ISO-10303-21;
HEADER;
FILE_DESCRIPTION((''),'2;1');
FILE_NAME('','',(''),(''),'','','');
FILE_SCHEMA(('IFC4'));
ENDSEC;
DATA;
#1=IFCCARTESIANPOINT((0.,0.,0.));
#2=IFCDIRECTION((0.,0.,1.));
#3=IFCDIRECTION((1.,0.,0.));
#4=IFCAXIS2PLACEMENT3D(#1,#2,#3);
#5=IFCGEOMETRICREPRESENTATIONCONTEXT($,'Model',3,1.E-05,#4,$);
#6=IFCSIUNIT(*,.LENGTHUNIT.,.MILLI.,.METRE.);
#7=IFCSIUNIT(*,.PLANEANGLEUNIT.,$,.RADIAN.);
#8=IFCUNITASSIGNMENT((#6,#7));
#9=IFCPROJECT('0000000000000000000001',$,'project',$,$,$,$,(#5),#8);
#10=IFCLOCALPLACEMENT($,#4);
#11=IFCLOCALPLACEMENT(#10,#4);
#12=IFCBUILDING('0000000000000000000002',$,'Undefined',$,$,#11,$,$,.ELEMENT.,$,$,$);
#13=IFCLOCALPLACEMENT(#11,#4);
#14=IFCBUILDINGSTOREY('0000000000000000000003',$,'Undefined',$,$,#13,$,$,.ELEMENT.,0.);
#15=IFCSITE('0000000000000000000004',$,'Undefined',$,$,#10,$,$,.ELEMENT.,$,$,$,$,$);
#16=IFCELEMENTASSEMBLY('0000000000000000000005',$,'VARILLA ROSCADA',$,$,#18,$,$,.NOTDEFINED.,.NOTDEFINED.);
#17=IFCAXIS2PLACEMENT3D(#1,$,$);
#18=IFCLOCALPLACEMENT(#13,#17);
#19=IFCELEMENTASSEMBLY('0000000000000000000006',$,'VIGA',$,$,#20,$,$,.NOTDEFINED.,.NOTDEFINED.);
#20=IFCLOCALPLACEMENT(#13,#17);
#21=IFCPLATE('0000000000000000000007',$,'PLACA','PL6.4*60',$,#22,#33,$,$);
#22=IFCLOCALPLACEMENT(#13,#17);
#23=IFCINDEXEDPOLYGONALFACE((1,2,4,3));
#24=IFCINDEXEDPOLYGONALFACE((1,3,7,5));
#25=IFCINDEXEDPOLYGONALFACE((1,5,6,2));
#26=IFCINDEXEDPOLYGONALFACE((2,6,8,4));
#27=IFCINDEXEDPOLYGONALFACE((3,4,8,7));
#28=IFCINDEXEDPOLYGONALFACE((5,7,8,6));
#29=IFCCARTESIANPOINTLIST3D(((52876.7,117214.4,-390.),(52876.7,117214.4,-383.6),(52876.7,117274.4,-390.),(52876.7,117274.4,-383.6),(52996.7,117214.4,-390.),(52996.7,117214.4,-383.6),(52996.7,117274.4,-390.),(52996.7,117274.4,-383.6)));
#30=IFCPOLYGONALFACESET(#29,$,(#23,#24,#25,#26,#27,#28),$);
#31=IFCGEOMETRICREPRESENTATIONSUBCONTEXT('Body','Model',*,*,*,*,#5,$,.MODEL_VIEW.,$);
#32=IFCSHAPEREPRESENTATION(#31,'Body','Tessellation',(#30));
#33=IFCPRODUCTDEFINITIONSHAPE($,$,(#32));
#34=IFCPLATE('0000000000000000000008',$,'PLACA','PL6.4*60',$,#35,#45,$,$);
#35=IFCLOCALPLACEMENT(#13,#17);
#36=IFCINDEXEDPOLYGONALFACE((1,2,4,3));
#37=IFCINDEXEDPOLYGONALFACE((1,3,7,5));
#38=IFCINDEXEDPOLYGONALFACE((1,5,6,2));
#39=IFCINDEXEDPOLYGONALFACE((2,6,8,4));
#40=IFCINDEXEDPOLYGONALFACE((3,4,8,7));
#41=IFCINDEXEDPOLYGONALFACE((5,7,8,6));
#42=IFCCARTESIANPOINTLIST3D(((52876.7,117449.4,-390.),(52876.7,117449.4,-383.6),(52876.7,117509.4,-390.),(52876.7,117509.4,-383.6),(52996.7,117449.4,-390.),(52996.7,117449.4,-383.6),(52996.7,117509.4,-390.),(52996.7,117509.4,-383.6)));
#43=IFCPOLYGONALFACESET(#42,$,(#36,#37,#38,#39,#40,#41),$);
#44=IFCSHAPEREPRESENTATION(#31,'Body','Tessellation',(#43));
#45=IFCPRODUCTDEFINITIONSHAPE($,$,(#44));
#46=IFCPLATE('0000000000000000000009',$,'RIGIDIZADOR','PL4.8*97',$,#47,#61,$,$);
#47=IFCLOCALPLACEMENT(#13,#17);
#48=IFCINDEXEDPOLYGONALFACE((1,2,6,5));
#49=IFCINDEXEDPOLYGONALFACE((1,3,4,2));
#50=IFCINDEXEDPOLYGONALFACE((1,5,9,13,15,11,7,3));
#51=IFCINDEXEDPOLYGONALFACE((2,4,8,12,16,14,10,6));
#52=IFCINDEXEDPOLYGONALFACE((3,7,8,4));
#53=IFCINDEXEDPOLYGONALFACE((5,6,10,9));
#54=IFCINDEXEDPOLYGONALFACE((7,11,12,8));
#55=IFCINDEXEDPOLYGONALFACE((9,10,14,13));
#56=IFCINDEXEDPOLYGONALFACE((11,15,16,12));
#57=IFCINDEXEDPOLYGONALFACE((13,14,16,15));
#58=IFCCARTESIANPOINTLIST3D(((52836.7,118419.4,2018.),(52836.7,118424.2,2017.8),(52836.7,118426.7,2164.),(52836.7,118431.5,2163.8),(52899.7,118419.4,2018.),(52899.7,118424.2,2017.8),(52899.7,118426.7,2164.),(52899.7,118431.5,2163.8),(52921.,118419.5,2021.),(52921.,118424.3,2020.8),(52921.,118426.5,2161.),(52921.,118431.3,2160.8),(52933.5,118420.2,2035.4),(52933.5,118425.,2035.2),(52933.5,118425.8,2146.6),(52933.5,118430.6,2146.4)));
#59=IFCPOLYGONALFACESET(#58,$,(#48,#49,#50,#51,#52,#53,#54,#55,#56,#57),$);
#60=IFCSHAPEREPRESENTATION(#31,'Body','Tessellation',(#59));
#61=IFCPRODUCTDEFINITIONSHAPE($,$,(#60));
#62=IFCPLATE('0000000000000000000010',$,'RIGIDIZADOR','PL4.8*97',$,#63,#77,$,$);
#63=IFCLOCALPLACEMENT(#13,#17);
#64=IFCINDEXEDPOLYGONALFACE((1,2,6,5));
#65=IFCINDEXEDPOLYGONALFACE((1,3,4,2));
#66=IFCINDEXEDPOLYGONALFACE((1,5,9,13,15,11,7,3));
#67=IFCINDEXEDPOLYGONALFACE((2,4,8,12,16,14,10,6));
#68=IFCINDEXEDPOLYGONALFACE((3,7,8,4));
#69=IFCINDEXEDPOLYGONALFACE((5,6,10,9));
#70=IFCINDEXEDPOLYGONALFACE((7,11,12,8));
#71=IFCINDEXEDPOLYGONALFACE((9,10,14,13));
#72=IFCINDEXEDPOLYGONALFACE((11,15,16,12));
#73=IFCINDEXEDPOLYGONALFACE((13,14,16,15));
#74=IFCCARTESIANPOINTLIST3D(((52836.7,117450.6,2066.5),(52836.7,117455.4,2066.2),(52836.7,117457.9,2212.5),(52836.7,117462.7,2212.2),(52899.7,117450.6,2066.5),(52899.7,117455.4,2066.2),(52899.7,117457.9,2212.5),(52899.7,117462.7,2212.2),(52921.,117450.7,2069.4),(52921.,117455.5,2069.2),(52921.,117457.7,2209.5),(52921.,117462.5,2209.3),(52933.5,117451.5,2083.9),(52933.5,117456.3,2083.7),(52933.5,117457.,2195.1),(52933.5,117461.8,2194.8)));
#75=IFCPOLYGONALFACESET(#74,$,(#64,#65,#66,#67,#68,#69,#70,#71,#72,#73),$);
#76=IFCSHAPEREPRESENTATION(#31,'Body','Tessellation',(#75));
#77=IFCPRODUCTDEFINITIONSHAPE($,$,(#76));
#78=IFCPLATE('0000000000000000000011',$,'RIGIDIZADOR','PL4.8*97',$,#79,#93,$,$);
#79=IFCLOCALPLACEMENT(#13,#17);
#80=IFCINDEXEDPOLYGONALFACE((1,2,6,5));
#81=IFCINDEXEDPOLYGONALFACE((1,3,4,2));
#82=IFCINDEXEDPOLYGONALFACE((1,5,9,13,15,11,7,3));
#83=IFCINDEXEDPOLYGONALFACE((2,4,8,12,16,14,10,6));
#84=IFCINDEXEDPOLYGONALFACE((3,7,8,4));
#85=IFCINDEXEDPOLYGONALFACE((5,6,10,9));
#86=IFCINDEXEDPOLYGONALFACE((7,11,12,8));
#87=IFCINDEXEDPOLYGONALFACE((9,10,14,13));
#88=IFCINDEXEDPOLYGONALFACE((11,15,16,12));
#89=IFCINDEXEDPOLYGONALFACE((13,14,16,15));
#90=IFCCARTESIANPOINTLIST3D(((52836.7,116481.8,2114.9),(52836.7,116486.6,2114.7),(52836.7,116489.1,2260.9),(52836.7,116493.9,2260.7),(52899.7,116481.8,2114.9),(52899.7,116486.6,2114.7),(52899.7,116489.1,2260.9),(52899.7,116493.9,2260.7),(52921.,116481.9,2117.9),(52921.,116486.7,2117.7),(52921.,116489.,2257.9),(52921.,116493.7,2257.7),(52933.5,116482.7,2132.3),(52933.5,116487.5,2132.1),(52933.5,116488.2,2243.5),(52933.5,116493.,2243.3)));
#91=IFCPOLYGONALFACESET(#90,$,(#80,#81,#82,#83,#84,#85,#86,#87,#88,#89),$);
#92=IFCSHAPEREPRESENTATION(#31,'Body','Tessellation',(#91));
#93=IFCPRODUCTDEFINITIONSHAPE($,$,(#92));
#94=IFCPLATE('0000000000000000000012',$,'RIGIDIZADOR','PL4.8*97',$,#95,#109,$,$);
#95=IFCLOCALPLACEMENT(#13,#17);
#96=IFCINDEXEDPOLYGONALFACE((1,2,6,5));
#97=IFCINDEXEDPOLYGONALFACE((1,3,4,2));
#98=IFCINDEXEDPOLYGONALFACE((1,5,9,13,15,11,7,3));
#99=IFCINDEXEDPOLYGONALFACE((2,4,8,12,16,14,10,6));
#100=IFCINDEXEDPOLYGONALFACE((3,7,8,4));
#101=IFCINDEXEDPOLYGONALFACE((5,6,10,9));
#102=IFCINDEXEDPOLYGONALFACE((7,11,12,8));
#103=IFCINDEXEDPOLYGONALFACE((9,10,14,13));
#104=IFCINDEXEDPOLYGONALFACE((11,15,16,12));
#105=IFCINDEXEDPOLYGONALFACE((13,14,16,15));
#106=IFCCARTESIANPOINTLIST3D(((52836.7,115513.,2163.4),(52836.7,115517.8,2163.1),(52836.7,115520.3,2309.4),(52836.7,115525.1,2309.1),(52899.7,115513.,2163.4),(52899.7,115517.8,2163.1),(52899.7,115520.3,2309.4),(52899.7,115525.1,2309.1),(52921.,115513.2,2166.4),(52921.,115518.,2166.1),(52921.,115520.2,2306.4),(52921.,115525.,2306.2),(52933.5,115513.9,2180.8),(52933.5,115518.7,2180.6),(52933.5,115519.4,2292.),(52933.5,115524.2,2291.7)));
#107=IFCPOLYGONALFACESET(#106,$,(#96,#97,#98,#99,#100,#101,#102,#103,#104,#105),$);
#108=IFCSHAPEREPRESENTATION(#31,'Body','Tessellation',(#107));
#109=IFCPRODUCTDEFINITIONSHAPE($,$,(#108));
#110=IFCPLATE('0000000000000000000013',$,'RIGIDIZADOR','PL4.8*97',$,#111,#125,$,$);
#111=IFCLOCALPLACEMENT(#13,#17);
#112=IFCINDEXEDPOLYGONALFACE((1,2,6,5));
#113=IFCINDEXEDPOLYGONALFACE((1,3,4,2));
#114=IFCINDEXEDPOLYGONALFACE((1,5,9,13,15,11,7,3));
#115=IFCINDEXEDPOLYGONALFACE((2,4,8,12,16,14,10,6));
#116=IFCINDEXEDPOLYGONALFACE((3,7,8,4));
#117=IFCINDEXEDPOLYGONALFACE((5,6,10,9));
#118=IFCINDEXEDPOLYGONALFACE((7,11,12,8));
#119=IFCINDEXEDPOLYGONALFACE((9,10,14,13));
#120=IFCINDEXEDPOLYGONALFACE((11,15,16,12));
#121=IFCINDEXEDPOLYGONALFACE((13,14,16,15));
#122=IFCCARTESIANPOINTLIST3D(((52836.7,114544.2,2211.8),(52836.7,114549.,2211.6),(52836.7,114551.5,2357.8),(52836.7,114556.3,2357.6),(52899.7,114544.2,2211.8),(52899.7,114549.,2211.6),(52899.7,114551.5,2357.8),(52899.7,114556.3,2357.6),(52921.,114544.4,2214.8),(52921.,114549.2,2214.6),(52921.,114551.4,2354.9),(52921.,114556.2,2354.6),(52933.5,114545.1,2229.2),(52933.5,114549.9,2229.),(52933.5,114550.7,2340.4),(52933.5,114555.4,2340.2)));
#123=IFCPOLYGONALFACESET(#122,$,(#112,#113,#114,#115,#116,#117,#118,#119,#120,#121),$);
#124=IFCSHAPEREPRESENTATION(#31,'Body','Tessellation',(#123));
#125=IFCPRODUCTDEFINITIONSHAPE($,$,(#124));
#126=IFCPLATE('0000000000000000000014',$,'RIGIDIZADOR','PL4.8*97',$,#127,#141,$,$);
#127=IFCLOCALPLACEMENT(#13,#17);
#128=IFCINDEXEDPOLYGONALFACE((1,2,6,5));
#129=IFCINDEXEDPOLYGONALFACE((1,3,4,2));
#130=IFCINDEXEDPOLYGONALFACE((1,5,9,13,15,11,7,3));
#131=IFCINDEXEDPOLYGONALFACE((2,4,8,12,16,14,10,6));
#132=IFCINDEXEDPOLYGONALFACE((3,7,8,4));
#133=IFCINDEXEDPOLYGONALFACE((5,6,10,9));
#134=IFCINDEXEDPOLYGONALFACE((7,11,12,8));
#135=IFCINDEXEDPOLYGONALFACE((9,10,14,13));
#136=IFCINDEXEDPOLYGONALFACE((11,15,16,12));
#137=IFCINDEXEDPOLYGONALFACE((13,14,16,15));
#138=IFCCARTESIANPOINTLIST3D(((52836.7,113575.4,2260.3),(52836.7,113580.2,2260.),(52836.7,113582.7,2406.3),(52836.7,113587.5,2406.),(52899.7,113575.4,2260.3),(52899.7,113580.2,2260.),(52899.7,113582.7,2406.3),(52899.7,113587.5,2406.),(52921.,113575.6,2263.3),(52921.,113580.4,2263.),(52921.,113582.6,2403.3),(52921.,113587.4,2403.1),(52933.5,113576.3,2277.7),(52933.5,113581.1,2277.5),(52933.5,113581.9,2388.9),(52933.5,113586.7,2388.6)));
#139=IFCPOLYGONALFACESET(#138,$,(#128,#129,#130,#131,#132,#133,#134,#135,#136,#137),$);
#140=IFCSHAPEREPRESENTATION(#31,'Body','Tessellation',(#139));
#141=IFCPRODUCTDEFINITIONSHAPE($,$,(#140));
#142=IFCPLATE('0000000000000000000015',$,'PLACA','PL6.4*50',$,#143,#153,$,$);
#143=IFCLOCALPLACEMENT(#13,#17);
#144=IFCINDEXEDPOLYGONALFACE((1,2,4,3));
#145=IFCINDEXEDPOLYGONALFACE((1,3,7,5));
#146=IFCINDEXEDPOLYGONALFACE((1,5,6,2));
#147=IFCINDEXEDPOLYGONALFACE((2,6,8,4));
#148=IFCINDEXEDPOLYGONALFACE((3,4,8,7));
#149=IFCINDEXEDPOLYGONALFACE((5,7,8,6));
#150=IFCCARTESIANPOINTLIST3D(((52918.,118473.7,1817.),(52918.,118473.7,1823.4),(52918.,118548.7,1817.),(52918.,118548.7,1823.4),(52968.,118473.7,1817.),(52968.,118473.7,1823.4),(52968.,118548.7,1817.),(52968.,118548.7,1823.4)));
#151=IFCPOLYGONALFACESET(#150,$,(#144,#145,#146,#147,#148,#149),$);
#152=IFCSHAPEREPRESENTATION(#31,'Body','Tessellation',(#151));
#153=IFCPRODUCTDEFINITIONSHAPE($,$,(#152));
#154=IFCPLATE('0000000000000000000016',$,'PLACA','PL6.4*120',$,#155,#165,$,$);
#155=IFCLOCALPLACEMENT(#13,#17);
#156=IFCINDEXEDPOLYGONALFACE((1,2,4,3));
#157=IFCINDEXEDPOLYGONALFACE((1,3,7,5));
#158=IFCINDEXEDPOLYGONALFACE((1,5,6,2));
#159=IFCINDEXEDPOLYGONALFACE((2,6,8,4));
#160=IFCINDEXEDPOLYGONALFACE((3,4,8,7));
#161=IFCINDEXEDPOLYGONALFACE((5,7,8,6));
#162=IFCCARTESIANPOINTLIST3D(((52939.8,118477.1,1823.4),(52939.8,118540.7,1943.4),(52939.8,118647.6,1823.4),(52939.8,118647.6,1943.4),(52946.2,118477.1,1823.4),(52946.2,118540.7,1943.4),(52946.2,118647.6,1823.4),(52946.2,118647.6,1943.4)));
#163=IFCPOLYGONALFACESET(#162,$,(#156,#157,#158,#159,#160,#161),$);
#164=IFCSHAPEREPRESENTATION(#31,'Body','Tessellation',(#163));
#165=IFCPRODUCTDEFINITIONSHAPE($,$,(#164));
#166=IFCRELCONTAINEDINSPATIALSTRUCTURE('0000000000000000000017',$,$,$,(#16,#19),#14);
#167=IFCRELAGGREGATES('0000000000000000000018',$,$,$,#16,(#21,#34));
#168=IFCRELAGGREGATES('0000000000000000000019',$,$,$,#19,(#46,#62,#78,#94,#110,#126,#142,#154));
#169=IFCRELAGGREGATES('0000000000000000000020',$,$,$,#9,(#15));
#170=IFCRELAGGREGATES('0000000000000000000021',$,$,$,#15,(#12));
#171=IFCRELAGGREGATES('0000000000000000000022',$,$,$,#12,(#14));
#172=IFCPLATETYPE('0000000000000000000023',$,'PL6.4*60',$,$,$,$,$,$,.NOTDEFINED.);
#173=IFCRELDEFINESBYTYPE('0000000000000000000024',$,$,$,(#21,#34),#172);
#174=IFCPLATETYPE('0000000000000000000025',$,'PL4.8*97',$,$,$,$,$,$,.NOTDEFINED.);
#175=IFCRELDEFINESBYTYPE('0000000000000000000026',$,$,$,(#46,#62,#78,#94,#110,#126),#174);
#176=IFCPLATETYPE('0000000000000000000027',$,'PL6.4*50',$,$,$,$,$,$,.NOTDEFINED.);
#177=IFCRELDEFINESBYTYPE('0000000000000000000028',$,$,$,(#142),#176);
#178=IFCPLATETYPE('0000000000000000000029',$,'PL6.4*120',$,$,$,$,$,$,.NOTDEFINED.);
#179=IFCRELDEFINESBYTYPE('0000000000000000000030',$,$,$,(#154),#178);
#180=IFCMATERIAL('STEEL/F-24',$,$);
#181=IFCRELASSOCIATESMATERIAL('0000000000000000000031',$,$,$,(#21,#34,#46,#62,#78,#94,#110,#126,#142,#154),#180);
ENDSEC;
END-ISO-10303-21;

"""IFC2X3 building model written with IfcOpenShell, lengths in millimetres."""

from ifc_helpers import new_model, si_unit, frame, origin_with_axes, place, context, subcontext, project, spatial, polyline, outline, extrude, material, type_object, element, aggregate, save


model = new_model("IFC2X3")

# Units and contexts
model_context = context("Model", 3, precision=1e-05, world=origin_with_axes())
body_context = subcontext(model_context, "Body", "Model", "MODEL_VIEW")
ifc_project = project(units=[si_unit("LENGTHUNIT", "METRE", prefix="MILLI"), si_unit("PLANEANGLEUNIT", "RADIAN")], contexts=[model_context])

# Site, building, storey
site_placement = place(None, origin_with_axes())
site = spatial("IfcSite", under=ifc_project, at=site_placement, Name="Undefined", CompositionType="ELEMENT")
building_placement = place(site_placement, origin_with_axes())
building = spatial("IfcBuilding", under=site, at=building_placement, Name="Undefined", CompositionType="ELEMENT")
storey_placement = place(building_placement, origin_with_axes())
storey = spatial("IfcBuildingStorey", under=building, at=storey_placement, Name="Undefined", CompositionType="ELEMENT", Elevation=0.0)

# Element assembly
assembly_1_placement = place(storey_placement, origin_with_axes())
assembly_1 = element("IfcElementAssembly", 1, at=assembly_1_placement, inside=storey, Name="VARILLA ROSCADA", AssemblyPlace="NOTDEFINED", PredefinedType="NOTDEFINED")

# Element assembly
assembly_2_placement = place(storey_placement, origin_with_axes())
assembly_2 = element("IfcElementAssembly", 2, at=assembly_2_placement, inside=storey, Name="VIGA", AssemblyPlace="NOTDEFINED", PredefinedType="NOTDEFINED")
ifc_material_1 = material(Name="STEEL/F-24")

# Plates
plate_type_1 = type_object("IfcPlateType", Name="PL6.4*60", PredefinedType="NOTDEFINED")
plate_1_placement = place(assembly_1_placement, frame((52876.7, 117214.4, -386.8), z_axis=(0.0, 0.0, 1.0), x_axis=(1.0, 0.0, 0.0)))
plate_1 = element("IfcPlate", 3, at=plate_1_placement, type_object=plate_type_1, material=ifc_material_1, Name="PLACA", Description="PL6.4*60", context=body_context, shape_type="SweptSolid", body=[
    extrude(outline(polyline([(0.0, 0.0), (120.0, 0.0), (120.0, 60.0), (0.0, 60.0), (0.0, 0.0)])), frame((0.0, 0.0, -3.2), z_axis=(0.0, 0.0, 1.0), x_axis=(1.0, 0.0, 0.0)), (0.0, 0.0, 1.0), 6.4),
])
plate_2_placement = place(assembly_1_placement, frame((52876.7, 117449.4, -386.8), z_axis=(0.0, 0.0, 1.0), x_axis=(1.0, 0.0, 0.0)))
plate_2 = element("IfcPlate", 4, at=plate_2_placement, type_object=plate_type_1, material=ifc_material_1, Name="PLACA", Description="PL6.4*60", context=body_context, shape_type="SweptSolid", body=[
    extrude(outline(polyline([(0.0, 0.0), (120.0, 0.0), (120.0, 60.0), (0.0, 60.0), (0.0, 0.0)])), frame((0.0, 0.0, -3.2), z_axis=(0.0, 0.0, 1.0), x_axis=(1.0, 0.0, 0.0)), (0.0, 0.0, 1.0), 6.4),
])
plate_type_2 = type_object("IfcPlateType", Name="PL4.8*97", PredefinedType="NOTDEFINED")
plate_3_placement = place(assembly_2_placement, frame((52836.7, 118429.1, 2163.9), z_axis=(0.0, 0.998752, -0.04995), x_axis=(1.0, 0.0, 0.0)))
plate_3 = element("IfcPlate", 5, at=plate_3_placement, type_object=plate_type_2, material=ifc_material_1, Name="RIGIDIZADOR", Description="PL4.8*97", context=body_context, shape_type="SweptSolid", body=[
    extrude(outline(polyline([(0.0, 0.0), (63.0, 0.0), (84.3, 3.0), (96.8, 17.4), (96.8, 128.7), (84.3, 143.2), (63.0, 146.2), (0.0, 146.2), (0.0, 0.0)])), frame((0.0, 0.0, -2.4), z_axis=(0.0, 0.0, 1.0), x_axis=(1.0, 0.0, 0.0)), (0.0, 0.0, 1.0), 4.8),
])
plate_4_placement = place(assembly_2_placement, frame((52836.7, 117460.3, 2212.4), z_axis=(0.0, 0.998752, -0.04995), x_axis=(1.0, 0.0, 0.0)))
plate_4 = element("IfcPlate", 6, at=plate_4_placement, type_object=plate_type_2, material=ifc_material_1, Name="RIGIDIZADOR", Description="PL4.8*97", context=body_context, shape_type="SweptSolid", body=[
    extrude(outline(polyline([(0.0, 0.0), (63.0, 0.0), (84.3, 3.0), (96.8, 17.4), (96.8, 128.7), (84.3, 143.2), (63.0, 146.2), (0.0, 146.2), (0.0, 0.0)])), frame((0.0, 0.0, -2.4), z_axis=(0.0, 0.0, 1.0), x_axis=(1.0, 0.0, 0.0)), (0.0, 0.0, 1.0), 4.8),
])
plate_5_placement = place(assembly_2_placement, frame((52836.7, 116491.5, 2260.8), z_axis=(0.0, 0.998752, -0.04995), x_axis=(1.0, 0.0, 0.0)))
plate_5 = element("IfcPlate", 7, at=plate_5_placement, type_object=plate_type_2, material=ifc_material_1, Name="RIGIDIZADOR", Description="PL4.8*97", context=body_context, shape_type="SweptSolid", body=[
    extrude(outline(polyline([(0.0, 0.0), (63.0, 0.0), (84.3, 3.0), (96.8, 17.4), (96.8, 128.7), (84.3, 143.2), (63.0, 146.2), (0.0, 146.2), (0.0, 0.0)])), frame((0.0, 0.0, -2.4), z_axis=(0.0, 0.0, 1.0), x_axis=(1.0, 0.0, 0.0)), (0.0, 0.0, 1.0), 4.8),
])
plate_6_placement = place(assembly_2_placement, frame((52836.7, 115522.7, 2309.3), z_axis=(0.0, 0.998752, -0.04995), x_axis=(1.0, 0.0, 0.0)))
plate_6 = element("IfcPlate", 8, at=plate_6_placement, type_object=plate_type_2, material=ifc_material_1, Name="RIGIDIZADOR", Description="PL4.8*97", context=body_context, shape_type="SweptSolid", body=[
    extrude(outline(polyline([(0.0, 0.0), (63.0, 0.0), (84.3, 3.0), (96.8, 17.4), (96.8, 128.7), (84.3, 143.2), (63.0, 146.2), (0.0, 146.2), (0.0, 0.0)])), frame((0.0, 0.0, -2.4), z_axis=(0.0, 0.0, 1.0), x_axis=(1.0, 0.0, 0.0)), (0.0, 0.0, 1.0), 4.8),
])
plate_7_placement = place(assembly_2_placement, frame((52836.7, 114553.9, 2357.7), z_axis=(0.0, 0.998752, -0.04995), x_axis=(1.0, 0.0, 0.0)))
plate_7 = element("IfcPlate", 9, at=plate_7_placement, type_object=plate_type_2, material=ifc_material_1, Name="RIGIDIZADOR", Description="PL4.8*97", context=body_context, shape_type="SweptSolid", body=[
    extrude(outline(polyline([(0.0, 0.0), (63.0, 0.0), (84.3, 3.0), (96.8, 17.4), (96.8, 128.7), (84.3, 143.2), (63.0, 146.2), (0.0, 146.2), (0.0, 0.0)])), frame((0.0, 0.0, -2.4), z_axis=(0.0, 0.0, 1.0), x_axis=(1.0, 0.0, 0.0)), (0.0, 0.0, 1.0), 4.8),
])
plate_8_placement = place(assembly_2_placement, frame((52836.7, 113585.1, 2406.2), z_axis=(0.0, 0.998752, -0.04995), x_axis=(1.0, 0.0, 0.0)))
plate_8 = element("IfcPlate", 10, at=plate_8_placement, type_object=plate_type_2, material=ifc_material_1, Name="RIGIDIZADOR", Description="PL4.8*97", context=body_context, shape_type="SweptSolid", body=[
    extrude(outline(polyline([(0.0, 0.0), (63.0, 0.0), (84.3, 3.0), (96.8, 17.4), (96.8, 128.7), (84.3, 143.2), (63.0, 146.2), (0.0, 146.2), (0.0, 0.0)])), frame((0.0, 0.0, -2.4), z_axis=(0.0, 0.0, 1.0), x_axis=(1.0, 0.0, 0.0)), (0.0, 0.0, 1.0), 4.8),
])
plate_type_3 = type_object("IfcPlateType", Name="PL6.4*50", PredefinedType="NOTDEFINED")
plate_9_placement = place(assembly_2_placement, frame((52918.0, 118473.7, 1820.2), z_axis=(0.0, 0.0, -1.0), x_axis=(0.0, 1.0, 0.0)))
plate_9 = element("IfcPlate", 11, at=plate_9_placement, type_object=plate_type_3, material=ifc_material_1, Name="PLACA", Description="PL6.4*50", context=body_context, shape_type="SweptSolid", body=[
    extrude(outline(polyline([(0.0, 0.0), (75.0, 0.0), (75.0, 50.0), (0.0, 50.0), (0.0, 0.0)])), frame((0.0, 0.0, -3.2), z_axis=(0.0, 0.0, 1.0), x_axis=(1.0, 0.0, 0.0)), (0.0, 0.0, 1.0), 6.4),
])
plate_type_4 = type_object("IfcPlateType", Name="PL6.4*120", PredefinedType="NOTDEFINED")
plate_10_placement = place(assembly_2_placement, frame((52943.0, 118540.7, 1943.4), z_axis=(-1.0, 0.0, 0.0), x_axis=(0.0, 1.0, 0.0)))
plate_10 = element("IfcPlate", 12, at=plate_10_placement, type_object=plate_type_4, material=ifc_material_1, Name="PLACA", Description="PL6.4*120", context=body_context, shape_type="SweptSolid", body=[
    extrude(outline(polyline([(0.0, 0.0), (106.8, 0.0), (106.8, 120.0), (-63.7, 120.0), (0.0, 0.0)])), frame((0.0, 0.0, -3.2), z_axis=(0.0, 0.0, 1.0), x_axis=(1.0, 0.0, 0.0)), (0.0, 0.0, 1.0), 6.4),
])

aggregate(assembly_1, [plate_1, plate_2])

aggregate(assembly_2, [plate_3, plate_4, plate_5, plate_6, plate_7, plate_8, plate_9, plate_10])

save(model, "model.ifc")
